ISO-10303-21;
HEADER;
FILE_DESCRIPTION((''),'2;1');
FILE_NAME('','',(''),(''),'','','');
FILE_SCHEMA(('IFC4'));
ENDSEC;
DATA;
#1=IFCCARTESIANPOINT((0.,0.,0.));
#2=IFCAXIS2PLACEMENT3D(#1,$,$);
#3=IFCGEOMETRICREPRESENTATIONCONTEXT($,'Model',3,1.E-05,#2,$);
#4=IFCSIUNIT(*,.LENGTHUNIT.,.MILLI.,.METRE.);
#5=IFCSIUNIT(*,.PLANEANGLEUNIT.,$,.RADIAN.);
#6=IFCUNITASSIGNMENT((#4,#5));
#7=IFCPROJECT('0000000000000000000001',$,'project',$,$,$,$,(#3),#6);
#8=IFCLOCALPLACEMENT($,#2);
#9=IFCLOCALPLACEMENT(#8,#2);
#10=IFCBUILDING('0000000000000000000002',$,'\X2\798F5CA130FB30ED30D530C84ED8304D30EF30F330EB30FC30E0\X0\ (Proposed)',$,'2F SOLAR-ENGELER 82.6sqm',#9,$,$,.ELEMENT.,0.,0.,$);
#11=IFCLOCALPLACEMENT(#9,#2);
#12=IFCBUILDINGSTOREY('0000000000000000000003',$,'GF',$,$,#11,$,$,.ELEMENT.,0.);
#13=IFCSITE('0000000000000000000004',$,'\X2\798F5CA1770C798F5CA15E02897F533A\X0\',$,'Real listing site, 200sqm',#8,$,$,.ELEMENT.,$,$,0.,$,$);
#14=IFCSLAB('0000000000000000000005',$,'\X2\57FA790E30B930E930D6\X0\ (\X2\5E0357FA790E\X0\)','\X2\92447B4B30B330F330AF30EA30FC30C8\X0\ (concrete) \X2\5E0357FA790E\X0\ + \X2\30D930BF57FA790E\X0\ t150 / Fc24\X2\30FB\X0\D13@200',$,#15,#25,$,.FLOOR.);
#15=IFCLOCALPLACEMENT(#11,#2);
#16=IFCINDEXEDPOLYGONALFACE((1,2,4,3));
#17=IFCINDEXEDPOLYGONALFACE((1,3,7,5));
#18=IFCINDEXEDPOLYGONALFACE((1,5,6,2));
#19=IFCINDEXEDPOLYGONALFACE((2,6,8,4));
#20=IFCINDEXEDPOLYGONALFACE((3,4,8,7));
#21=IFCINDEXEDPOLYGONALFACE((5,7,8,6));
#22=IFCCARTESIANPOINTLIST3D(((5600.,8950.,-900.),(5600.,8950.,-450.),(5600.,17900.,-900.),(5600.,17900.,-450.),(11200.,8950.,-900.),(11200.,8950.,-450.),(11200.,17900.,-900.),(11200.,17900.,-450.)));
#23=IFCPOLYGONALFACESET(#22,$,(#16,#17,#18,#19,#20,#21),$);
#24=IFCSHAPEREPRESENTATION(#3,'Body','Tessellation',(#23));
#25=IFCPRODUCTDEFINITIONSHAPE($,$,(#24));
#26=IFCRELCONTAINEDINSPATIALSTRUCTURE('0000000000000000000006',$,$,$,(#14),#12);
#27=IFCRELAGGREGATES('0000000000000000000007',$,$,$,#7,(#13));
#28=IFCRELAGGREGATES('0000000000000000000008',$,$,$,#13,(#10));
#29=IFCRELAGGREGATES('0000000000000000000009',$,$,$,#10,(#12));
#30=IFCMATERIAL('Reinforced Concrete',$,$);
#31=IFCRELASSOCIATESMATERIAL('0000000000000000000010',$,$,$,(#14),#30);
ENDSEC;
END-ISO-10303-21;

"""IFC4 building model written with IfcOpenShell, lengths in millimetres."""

from ifc_helpers import new_model, si_unit, frame, frame_2d, origin, place, context, project, spatial, rectangle, extrude, material, element, save


model = new_model("IFC4")

# Units and contexts
model_context = context("Model", 3, precision=1e-05, world=origin())
ifc_project = project(units=[si_unit("LENGTHUNIT", "METRE", prefix="MILLI"), si_unit("PLANEANGLEUNIT", "RADIAN")], contexts=[model_context])

# Site, building, storey
site_placement = place(None, origin())
site = spatial("IfcSite", under=ifc_project, at=site_placement, Name="福岡県福岡市西区", ObjectType="Real listing site, 200sqm", CompositionType="ELEMENT", RefElevation=0.0)
building_placement = place(site_placement, origin())
building = spatial("IfcBuilding", under=site, at=building_placement, Name="福岡・ロフト付きワンルーム (Proposed)", ObjectType="2F SOLAR-ENGELER 82.6sqm", CompositionType="ELEMENT", ElevationOfRefHeight=0.0, ElevationOfTerrain=0.0)
storey_placement = place(building_placement, origin())
storey = spatial("IfcBuildingStorey", under=building, at=storey_placement, Name="GF", CompositionType="ELEMENT", Elevation=0.0)

# Slab
ifc_material_1 = material(Name="Reinforced Concrete")
slab_1_placement = place(storey_placement, frame((2800.0, 4475.0, -450.0)))
element("IfcSlab", 1, at=slab_1_placement, inside=storey, material=ifc_material_1, Name="基礎スラブ (布基礎)", Description="鉄筋コンクリート (concrete) 布基礎 + ベタ基礎 t150 / Fc24・D13@200", PredefinedType="FLOOR", context=model_context, shape_type="SweptSolid", body=[
    extrude(rectangle(XDim=5600.0, YDim=8950.0, at=frame_2d((2800.0, 4475.0))), frame((2800.0, 4475.0, -450.0)), (0.0, 0.0, 1.0), 450.0),
])

save(model, "model.ifc")
